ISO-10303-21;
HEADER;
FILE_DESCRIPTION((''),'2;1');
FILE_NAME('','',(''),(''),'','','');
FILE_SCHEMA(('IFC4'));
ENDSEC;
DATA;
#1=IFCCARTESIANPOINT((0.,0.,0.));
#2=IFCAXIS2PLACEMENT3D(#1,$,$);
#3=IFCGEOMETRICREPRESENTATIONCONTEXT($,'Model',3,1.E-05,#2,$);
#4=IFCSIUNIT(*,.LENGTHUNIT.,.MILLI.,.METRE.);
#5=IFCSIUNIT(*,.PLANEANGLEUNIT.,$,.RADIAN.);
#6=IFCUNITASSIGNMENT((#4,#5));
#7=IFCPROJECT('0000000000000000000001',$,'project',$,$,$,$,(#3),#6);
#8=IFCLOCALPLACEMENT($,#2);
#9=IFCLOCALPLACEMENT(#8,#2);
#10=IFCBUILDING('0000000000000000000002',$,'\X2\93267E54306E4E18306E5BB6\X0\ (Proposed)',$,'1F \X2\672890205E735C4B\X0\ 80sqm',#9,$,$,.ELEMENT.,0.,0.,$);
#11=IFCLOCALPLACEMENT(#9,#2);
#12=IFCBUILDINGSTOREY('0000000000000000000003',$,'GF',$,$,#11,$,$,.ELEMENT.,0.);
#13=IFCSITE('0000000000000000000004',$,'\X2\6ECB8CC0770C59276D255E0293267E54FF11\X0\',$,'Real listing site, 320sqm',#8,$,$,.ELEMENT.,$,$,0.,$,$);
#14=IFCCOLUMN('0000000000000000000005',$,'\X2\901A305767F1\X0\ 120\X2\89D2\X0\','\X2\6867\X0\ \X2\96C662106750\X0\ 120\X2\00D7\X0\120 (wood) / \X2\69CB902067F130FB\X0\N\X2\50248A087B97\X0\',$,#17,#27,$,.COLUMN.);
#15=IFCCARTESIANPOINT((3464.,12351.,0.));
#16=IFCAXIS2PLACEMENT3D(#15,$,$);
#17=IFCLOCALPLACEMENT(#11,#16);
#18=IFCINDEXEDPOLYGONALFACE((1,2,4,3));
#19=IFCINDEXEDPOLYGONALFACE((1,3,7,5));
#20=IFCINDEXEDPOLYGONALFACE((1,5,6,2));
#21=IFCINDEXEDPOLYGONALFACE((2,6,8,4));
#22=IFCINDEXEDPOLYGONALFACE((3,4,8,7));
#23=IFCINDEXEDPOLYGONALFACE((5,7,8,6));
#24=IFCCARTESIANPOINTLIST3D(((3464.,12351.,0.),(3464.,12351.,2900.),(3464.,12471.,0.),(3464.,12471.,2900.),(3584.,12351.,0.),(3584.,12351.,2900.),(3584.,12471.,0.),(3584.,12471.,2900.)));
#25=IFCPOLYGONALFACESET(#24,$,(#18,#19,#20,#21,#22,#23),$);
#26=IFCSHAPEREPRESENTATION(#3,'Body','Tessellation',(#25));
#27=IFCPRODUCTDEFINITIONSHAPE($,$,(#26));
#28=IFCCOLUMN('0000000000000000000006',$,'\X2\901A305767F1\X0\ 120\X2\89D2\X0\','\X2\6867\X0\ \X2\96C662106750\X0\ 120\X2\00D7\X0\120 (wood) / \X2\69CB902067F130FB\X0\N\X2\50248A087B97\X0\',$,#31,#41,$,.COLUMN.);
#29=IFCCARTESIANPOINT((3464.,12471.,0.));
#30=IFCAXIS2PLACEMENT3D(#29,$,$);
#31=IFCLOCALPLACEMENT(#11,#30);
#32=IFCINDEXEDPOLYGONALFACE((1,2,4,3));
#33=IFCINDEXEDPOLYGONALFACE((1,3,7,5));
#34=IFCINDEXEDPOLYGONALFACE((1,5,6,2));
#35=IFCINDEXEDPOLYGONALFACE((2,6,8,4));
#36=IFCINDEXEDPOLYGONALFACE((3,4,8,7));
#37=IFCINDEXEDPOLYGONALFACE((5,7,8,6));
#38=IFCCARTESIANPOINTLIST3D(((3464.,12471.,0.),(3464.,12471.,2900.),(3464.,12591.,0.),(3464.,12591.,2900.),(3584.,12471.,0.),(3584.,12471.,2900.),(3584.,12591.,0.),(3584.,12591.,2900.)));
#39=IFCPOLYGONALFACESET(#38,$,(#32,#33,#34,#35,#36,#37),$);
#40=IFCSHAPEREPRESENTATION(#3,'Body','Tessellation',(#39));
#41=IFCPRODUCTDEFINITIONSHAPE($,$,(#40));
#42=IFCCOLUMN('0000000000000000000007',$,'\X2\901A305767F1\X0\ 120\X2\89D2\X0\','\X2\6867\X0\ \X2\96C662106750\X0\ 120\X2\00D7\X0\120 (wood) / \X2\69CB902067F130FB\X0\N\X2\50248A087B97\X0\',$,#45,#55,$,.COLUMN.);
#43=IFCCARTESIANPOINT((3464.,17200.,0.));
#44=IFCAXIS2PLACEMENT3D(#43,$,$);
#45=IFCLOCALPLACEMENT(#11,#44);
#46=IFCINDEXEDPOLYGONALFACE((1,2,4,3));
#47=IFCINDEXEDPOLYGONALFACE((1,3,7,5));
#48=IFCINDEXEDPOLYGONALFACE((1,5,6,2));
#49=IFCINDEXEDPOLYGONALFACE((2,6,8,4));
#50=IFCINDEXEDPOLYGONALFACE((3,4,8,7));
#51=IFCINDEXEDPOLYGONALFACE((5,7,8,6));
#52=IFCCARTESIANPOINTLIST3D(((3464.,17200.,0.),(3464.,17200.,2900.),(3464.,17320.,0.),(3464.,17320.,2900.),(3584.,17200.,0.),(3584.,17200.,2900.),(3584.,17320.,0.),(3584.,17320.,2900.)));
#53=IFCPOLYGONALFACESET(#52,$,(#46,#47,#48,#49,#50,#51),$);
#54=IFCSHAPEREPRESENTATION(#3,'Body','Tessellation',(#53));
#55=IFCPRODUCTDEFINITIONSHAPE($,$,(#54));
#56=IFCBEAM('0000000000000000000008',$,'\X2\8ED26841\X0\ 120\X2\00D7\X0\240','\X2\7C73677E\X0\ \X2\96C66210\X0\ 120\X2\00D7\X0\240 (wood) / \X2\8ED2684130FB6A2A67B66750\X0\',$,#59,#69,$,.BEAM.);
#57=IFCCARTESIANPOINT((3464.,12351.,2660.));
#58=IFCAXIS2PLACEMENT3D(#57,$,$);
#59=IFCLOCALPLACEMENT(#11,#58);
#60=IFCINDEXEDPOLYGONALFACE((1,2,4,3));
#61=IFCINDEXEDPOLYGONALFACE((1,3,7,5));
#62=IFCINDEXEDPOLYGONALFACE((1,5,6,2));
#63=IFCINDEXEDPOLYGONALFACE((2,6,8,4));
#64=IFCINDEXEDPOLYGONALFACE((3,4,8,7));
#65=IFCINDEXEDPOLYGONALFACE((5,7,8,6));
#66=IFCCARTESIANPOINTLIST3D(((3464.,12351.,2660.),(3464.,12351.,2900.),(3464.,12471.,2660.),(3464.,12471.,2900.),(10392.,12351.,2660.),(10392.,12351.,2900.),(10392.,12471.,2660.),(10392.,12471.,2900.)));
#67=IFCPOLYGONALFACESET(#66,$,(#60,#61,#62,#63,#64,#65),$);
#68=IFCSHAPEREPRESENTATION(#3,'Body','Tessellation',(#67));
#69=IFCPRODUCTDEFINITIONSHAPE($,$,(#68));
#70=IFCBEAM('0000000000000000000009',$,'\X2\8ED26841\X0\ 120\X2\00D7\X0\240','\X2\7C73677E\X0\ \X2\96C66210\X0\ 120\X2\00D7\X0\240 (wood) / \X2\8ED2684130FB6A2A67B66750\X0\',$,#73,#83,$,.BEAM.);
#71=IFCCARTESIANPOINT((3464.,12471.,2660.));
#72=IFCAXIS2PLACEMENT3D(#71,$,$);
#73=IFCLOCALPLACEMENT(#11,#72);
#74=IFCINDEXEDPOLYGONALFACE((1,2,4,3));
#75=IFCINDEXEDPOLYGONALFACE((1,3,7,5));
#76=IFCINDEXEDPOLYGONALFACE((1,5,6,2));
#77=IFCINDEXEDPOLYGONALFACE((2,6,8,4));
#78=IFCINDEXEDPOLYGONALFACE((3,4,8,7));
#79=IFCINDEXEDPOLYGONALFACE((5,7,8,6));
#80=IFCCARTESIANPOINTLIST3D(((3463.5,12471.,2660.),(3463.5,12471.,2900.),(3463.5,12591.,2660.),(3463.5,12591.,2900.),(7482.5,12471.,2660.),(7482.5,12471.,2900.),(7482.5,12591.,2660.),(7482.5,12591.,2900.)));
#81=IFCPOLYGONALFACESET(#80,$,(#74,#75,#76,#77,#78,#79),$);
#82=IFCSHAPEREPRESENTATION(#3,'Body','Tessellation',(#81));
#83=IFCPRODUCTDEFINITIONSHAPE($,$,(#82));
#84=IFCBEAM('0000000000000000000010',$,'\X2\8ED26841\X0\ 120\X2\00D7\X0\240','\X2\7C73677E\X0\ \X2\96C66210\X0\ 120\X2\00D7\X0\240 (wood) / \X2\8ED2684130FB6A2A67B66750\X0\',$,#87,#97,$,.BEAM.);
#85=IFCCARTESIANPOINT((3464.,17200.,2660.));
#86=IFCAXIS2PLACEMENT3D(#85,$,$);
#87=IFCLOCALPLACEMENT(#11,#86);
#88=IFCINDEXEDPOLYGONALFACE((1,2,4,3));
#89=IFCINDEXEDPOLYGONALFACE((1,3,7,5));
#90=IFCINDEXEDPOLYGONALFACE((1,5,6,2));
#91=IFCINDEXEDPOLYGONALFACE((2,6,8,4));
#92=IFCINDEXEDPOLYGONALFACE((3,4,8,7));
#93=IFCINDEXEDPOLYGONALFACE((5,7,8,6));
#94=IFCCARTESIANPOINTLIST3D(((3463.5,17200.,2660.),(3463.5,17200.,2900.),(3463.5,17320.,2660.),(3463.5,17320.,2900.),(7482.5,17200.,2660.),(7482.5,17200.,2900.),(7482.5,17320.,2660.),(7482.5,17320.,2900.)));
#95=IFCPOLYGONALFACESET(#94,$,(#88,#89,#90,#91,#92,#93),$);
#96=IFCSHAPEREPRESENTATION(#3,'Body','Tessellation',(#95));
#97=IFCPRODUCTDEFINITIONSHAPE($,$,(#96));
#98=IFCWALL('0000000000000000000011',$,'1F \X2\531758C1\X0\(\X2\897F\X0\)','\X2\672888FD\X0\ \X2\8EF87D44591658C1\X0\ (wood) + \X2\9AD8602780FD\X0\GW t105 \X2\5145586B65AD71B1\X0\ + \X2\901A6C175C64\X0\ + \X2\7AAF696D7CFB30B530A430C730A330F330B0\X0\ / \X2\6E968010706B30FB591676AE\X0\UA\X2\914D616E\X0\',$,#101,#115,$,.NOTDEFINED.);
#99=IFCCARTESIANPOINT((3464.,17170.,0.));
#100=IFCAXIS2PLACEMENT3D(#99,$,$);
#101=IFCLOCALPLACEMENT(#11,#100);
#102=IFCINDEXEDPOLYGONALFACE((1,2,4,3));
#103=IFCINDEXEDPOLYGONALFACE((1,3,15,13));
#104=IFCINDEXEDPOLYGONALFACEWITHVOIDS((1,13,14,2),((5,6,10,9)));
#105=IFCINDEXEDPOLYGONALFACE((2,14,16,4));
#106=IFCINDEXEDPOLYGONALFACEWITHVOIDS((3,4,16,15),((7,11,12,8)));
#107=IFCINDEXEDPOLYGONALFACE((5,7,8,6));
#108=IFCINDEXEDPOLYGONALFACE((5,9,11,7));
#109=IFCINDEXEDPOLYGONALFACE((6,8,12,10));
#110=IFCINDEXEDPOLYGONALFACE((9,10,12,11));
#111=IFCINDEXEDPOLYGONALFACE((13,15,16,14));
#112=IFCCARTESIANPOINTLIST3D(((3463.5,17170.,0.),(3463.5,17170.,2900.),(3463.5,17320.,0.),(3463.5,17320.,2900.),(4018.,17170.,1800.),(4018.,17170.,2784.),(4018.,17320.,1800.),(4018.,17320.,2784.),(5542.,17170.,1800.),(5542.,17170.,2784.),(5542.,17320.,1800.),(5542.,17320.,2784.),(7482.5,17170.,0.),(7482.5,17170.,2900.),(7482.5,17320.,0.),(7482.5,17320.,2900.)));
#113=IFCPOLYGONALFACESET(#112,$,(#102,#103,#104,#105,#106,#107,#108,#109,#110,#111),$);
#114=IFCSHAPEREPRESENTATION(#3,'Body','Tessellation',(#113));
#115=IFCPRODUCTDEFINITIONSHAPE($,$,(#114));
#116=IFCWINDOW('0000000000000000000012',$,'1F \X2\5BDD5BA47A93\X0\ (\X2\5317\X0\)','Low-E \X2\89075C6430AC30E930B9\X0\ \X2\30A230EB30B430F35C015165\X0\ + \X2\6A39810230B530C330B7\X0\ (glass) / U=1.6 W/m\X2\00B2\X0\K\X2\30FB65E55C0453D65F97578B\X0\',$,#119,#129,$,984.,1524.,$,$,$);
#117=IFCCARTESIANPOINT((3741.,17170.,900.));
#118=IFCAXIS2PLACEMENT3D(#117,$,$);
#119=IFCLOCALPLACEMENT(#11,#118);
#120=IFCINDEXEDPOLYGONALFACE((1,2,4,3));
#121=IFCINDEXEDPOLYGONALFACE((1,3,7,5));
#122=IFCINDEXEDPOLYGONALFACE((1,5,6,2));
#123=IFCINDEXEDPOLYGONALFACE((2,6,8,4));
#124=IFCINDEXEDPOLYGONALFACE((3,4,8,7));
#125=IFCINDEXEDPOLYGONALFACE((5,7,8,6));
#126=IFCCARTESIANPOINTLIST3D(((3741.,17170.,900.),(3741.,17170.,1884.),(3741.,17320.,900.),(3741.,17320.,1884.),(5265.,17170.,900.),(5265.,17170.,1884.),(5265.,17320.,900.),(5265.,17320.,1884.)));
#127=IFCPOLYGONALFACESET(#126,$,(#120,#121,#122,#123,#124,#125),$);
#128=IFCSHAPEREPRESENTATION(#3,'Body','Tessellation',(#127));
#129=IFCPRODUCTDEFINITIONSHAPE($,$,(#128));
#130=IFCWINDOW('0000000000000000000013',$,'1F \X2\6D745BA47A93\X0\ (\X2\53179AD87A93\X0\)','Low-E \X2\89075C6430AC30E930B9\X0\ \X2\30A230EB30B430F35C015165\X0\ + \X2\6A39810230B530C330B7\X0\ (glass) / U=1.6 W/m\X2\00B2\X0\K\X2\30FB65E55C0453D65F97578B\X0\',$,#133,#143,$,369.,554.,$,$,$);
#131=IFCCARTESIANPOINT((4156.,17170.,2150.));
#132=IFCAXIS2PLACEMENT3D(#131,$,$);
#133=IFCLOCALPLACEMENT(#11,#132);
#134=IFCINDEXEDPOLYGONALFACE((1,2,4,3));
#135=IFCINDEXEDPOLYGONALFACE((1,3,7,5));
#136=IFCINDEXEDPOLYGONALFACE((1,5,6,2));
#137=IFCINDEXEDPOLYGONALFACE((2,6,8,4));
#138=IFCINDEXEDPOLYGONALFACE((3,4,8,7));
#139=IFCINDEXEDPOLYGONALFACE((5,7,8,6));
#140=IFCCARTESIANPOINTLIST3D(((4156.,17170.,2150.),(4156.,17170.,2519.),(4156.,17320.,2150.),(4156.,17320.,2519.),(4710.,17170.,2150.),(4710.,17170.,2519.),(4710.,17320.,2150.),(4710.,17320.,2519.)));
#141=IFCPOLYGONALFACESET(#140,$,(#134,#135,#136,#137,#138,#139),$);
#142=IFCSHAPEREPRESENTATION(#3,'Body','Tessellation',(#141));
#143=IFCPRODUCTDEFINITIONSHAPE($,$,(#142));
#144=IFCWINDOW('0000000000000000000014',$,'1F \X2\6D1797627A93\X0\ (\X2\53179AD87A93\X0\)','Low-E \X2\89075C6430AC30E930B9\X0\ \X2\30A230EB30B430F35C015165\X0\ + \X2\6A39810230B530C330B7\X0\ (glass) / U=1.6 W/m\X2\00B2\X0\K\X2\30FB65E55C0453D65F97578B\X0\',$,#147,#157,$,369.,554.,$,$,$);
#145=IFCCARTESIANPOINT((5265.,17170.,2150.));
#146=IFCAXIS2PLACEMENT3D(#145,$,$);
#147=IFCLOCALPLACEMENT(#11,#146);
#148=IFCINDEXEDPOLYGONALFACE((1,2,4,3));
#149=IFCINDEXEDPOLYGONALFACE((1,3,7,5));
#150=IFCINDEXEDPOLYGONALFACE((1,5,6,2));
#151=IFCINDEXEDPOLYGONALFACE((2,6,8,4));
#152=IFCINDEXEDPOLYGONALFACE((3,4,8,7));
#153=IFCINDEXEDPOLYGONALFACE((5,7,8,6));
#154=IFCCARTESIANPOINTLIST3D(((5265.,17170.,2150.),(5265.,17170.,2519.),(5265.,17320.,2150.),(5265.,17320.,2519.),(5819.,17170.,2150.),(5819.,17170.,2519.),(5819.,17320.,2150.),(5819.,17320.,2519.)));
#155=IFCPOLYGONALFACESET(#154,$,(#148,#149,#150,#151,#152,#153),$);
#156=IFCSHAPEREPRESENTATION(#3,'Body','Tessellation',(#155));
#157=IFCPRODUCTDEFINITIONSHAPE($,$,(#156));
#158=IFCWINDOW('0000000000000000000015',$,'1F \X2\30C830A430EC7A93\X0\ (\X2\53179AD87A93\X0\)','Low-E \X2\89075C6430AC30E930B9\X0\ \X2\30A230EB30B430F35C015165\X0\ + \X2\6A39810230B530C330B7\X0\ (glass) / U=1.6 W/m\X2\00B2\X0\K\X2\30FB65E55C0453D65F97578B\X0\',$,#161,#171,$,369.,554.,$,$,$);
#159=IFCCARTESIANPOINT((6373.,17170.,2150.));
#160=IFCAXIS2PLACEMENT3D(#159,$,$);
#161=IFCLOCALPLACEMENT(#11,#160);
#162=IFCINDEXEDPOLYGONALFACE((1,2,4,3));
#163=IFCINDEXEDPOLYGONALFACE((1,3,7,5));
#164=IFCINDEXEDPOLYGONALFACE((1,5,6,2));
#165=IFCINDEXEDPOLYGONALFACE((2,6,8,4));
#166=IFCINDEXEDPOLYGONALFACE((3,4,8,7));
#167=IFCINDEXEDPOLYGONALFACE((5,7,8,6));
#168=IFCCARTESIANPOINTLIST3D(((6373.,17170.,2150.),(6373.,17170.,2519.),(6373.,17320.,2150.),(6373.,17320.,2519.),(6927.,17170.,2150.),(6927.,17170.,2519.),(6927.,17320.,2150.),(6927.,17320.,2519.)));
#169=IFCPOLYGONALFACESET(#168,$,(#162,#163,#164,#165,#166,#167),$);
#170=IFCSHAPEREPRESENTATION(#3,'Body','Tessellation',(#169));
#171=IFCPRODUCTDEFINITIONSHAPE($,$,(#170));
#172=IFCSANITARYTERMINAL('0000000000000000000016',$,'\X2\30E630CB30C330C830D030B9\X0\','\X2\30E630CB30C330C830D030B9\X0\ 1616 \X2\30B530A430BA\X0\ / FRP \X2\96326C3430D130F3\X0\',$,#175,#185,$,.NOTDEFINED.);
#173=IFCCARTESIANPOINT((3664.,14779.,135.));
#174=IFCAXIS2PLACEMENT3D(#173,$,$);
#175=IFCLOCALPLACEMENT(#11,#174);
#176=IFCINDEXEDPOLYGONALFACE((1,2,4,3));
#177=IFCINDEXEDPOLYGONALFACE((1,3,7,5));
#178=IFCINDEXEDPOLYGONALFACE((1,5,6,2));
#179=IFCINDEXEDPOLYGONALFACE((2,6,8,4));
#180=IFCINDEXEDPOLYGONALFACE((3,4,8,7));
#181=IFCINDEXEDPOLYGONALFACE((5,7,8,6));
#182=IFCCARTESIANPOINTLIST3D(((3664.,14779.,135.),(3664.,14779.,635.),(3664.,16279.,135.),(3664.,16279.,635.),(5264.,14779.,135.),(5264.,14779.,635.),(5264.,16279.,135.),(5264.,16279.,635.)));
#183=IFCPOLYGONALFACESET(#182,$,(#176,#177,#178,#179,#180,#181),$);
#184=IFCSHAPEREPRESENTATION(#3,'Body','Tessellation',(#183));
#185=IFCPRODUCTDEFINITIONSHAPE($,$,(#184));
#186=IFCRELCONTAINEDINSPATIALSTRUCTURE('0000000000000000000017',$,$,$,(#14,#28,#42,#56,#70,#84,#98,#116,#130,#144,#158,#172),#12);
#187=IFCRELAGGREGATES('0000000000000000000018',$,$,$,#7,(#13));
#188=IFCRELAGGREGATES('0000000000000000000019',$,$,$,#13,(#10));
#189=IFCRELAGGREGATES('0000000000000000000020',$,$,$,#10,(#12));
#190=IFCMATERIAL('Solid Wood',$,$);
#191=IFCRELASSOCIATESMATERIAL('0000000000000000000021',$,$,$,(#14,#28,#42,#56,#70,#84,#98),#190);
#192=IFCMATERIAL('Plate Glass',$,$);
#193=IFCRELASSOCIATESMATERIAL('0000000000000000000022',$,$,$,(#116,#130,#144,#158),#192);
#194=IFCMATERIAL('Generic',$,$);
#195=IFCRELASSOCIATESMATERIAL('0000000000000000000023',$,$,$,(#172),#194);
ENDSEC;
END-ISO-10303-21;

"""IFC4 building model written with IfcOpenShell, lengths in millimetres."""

from ifc_helpers import new_model, si_unit, frame, frame_2d, origin, place, context, project, spatial, rectangle, extrude, material, element, fill, save


model = new_model("IFC4")

# Units and contexts
model_context = context("Model", 3, precision=1e-05, world=origin())
ifc_project = project(units=[si_unit("LENGTHUNIT", "METRE", prefix="MILLI"), si_unit("PLANEANGLEUNIT", "RADIAN")], contexts=[model_context])

# Site, building, storey
site_placement = place(None, origin())
site = spatial("IfcSite", under=ifc_project, at=site_placement, Name="滋賀県大津市錦織１", ObjectType="Real listing site, 320sqm", CompositionType="ELEMENT", RefElevation=0.0)
building_placement = place(site_placement, origin())
building = spatial("IfcBuilding", under=site, at=building_placement, Name="錦織の丘の家 (Proposed)", ObjectType="1F 木造平屋 80sqm", CompositionType="ELEMENT", ElevationOfRefHeight=0.0, ElevationOfTerrain=0.0)
storey_placement = place(building_placement, origin())
storey = spatial("IfcBuildingStorey", under=building, at=storey_placement, Name="GF", CompositionType="ELEMENT", Elevation=0.0)

# Columns
ifc_material_1 = material(Name="Solid Wood")
column_1_placement = place(storey_placement, frame((3464.0, 12351.0, 0.0)))
element("IfcColumn", 1, at=column_1_placement, inside=storey, material=ifc_material_1, Name="通し柱 120角", Description="桧 集成材 120×120 (wood) / 構造柱・N値計算", PredefinedType="COLUMN", context=model_context, shape_type="SweptSolid", body=[
    extrude(rectangle(XDim=120.0, YDim=120.0, at=frame_2d((60.0, 60.0))), frame((3464.0, 12351.0, 0.0)), (0.0, 0.0, 1.0), 2900.0),
])
column_2_placement = place(storey_placement, frame((3464.0, 12471.0, 0.0)))
element("IfcColumn", 2, at=column_2_placement, inside=storey, material=ifc_material_1, Name="通し柱 120角", Description="桧 集成材 120×120 (wood) / 構造柱・N値計算", PredefinedType="COLUMN", context=model_context, shape_type="SweptSolid", body=[
    extrude(rectangle(XDim=120.0, YDim=120.0, at=frame_2d((60.0, 60.0))), frame((3464.0, 12471.0, 0.0)), (0.0, 0.0, 1.0), 2900.0),
])
column_3_placement = place(storey_placement, frame((3464.0, 17200.0, 0.0)))
element("IfcColumn", 3, at=column_3_placement, inside=storey, material=ifc_material_1, Name="通し柱 120角", Description="桧 集成材 120×120 (wood) / 構造柱・N値計算", PredefinedType="COLUMN", context=model_context, shape_type="SweptSolid", body=[
    extrude(rectangle(XDim=120.0, YDim=120.0, at=frame_2d((60.0, 60.0))), frame((3464.0, 17200.0, 0.0)), (0.0, 0.0, 1.0), 2900.0),
])

# Beams
beam_1_placement = place(storey_placement, frame((3464.0, 12351.0, 2660.0)))
element("IfcBeam", 4, at=beam_1_placement, inside=storey, material=ifc_material_1, Name="軒桁 120×240", Description="米松 集成 120×240 (wood) / 軒桁・横架材", PredefinedType="BEAM", context=model_context, shape_type="SweptSolid", body=[
    extrude(rectangle(XDim=6928.0, YDim=120.0, at=frame_2d((3464.0, 60.0))), frame((3464.0, 12351.0, 2660.0)), (0.0, 0.0, 1.0), 240.0),
])
beam_2_placement = place(storey_placement, frame((3464.0, 12471.0, 2660.0)))
element("IfcBeam", 5, at=beam_2_placement, inside=storey, material=ifc_material_1, Name="軒桁 120×240", Description="米松 集成 120×240 (wood) / 軒桁・横架材", PredefinedType="BEAM", context=model_context, shape_type="SweptSolid", body=[
    extrude(rectangle(XDim=4019.0, YDim=120.0, at=frame_2d((2009.0, 60.0))), frame((3464.0, 12471.0, 2660.0)), (0.0, 0.0, 1.0), 240.0),
])
beam_3_placement = place(storey_placement, frame((3464.0, 17200.0, 2660.0)))
element("IfcBeam", 6, at=beam_3_placement, inside=storey, material=ifc_material_1, Name="軒桁 120×240", Description="米松 集成 120×240 (wood) / 軒桁・横架材", PredefinedType="BEAM", context=model_context, shape_type="SweptSolid", body=[
    extrude(rectangle(XDim=4019.0, YDim=120.0, at=frame_2d((2009.0, 60.0))), frame((3464.0, 17200.0, 2660.0)), (0.0, 0.0, 1.0), 240.0),
])

# Wall, openings, windows
wall_1_placement = place(storey_placement, frame((3464.0, 17170.0, 0.0)))
wall_1 = element("IfcWall", 7, at=wall_1_placement, inside=storey, material=ifc_material_1, Name="1F 北壁(西)", Description="木製 軸組外壁 (wood) + 高性能GW t105 充填断熱 + 通気層 + 窯業系サイディング / 準耐火・外皮UA配慮", PredefinedType="NOTDEFINED", context=model_context, shape_type="SweptSolid", body=[
    extrude(rectangle(XDim=4019.0, YDim=150.0, at=frame_2d((2009.0, 75.0))), frame((3464.0, 17170.0, 0.0)), (0.0, 0.0, 1.0), 2900.0),
])
opening_1_placement = place(storey_placement, frame((3741.0, 17170.0, 900.0)))
opening_1 = element("IfcOpeningElement", 8, at=opening_1_placement, cuts=wall_1, PredefinedType="NOTDEFINED", context=model_context, shape_type="SweptSolid", body=[
    extrude(rectangle(XDim=1524.0, YDim=150.0, at=frame_2d((762.0, 75.0))), frame((3741.0, 17170.0, 900.0)), (0.0, 0.0, 1.0), 984.0),
])
opening_2_placement = place(storey_placement, frame((4156.0, 17170.0, 2150.0)))
opening_2 = element("IfcOpeningElement", 9, at=opening_2_placement, cuts=wall_1, PredefinedType="NOTDEFINED", context=model_context, shape_type="SweptSolid", body=[
    extrude(rectangle(XDim=554.0, YDim=150.0, at=frame_2d((277.0, 75.0))), frame((4156.0, 17170.0, 2150.0)), (0.0, 0.0, 1.0), 369.0),
])
opening_3_placement = place(storey_placement, frame((5265.0, 17170.0, 2150.0)))
opening_3 = element("IfcOpeningElement", 10, at=opening_3_placement, cuts=wall_1, PredefinedType="NOTDEFINED", context=model_context, shape_type="SweptSolid", body=[
    extrude(rectangle(XDim=554.0, YDim=150.0, at=frame_2d((277.0, 75.0))), frame((5265.0, 17170.0, 2150.0)), (0.0, 0.0, 1.0), 369.0),
])
opening_4_placement = place(storey_placement, frame((6373.0, 17170.0, 2150.0)))
opening_4 = element("IfcOpeningElement", 11, at=opening_4_placement, cuts=wall_1, PredefinedType="NOTDEFINED", context=model_context, shape_type="SweptSolid", body=[
    extrude(rectangle(XDim=554.0, YDim=150.0, at=frame_2d((277.0, 75.0))), frame((6373.0, 17170.0, 2150.0)), (0.0, 0.0, 1.0), 369.0),
])
ifc_material_2 = material(Name="Plate Glass")
window_1_placement = place(storey_placement, frame((3741.0, 17170.0, 900.0)))
window_1 = element("IfcWindow", 12, at=window_1_placement, inside=storey, material=ifc_material_2, Name="1F 寝室窓 (北)", Description="Low-E 複層ガラス アルゴン封入 + 樹脂サッシ (glass) / U=1.6 W/m²K・日射取得型", OverallHeight=984.0, OverallWidth=1524.0, context=model_context, shape_type="SweptSolid", body=[
    extrude(rectangle(XDim=1524.0, YDim=150.0, at=frame_2d((762.0, 75.0))), frame((3741.0, 17170.0, 900.0)), (0.0, 0.0, 1.0), 984.0),
])
fill(opening_1, window_1)
window_2_placement = place(storey_placement, frame((4156.0, 17170.0, 2150.0)))
window_2 = element("IfcWindow", 13, at=window_2_placement, inside=storey, material=ifc_material_2, Name="1F 浴室窓 (北高窓)", Description="Low-E 複層ガラス アルゴン封入 + 樹脂サッシ (glass) / U=1.6 W/m²K・日射取得型", OverallHeight=369.0, OverallWidth=554.0, context=model_context, shape_type="SweptSolid", body=[
    extrude(rectangle(XDim=554.0, YDim=150.0, at=frame_2d((277.0, 75.0))), frame((4156.0, 17170.0, 2150.0)), (0.0, 0.0, 1.0), 369.0),
])
fill(opening_2, window_2)
window_3_placement = place(storey_placement, frame((5265.0, 17170.0, 2150.0)))
window_3 = element("IfcWindow", 14, at=window_3_placement, inside=storey, material=ifc_material_2, Name="1F 洗面窓 (北高窓)", Description="Low-E 複層ガラス アルゴン封入 + 樹脂サッシ (glass) / U=1.6 W/m²K・日射取得型", OverallHeight=369.0, OverallWidth=554.0, context=model_context, shape_type="SweptSolid", body=[
    extrude(rectangle(XDim=554.0, YDim=150.0, at=frame_2d((277.0, 75.0))), frame((5265.0, 17170.0, 2150.0)), (0.0, 0.0, 1.0), 369.0),
])
fill(opening_3, window_3)
window_4_placement = place(storey_placement, frame((6373.0, 17170.0, 2150.0)))
window_4 = element("IfcWindow", 15, at=window_4_placement, inside=storey, material=ifc_material_2, Name="1F トイレ窓 (北高窓)", Description="Low-E 複層ガラス アルゴン封入 + 樹脂サッシ (glass) / U=1.6 W/m²K・日射取得型", OverallHeight=369.0, OverallWidth=554.0, context=model_context, shape_type="SweptSolid", body=[
    extrude(rectangle(XDim=554.0, YDim=150.0, at=frame_2d((277.0, 75.0))), frame((6373.0, 17170.0, 2150.0)), (0.0, 0.0, 1.0), 369.0),
])
fill(opening_4, window_4)

# Shared definitions
ifc_material_3 = material(Name="Generic")

# Sanitary terminal
sanitary_terminal_placement = place(storey_placement, frame((3664.0, 14779.0, 135.0)))
element("IfcSanitaryTerminal", 16, at=sanitary_terminal_placement, inside=storey, material=ifc_material_3, Name="ユニットバス", Description="ユニットバス 1616 サイズ / FRP 防水パン", PredefinedType="NOTDEFINED", context=model_context, shape_type="SweptSolid", body=[
    extrude(rectangle(XDim=1600.0, YDim=1500.0, at=frame_2d((800.0, 750.0))), frame((3664.0, 14779.0, 135.0)), (0.0, 0.0, 1.0), 500.0),
])

save(model, "model.ifc")
